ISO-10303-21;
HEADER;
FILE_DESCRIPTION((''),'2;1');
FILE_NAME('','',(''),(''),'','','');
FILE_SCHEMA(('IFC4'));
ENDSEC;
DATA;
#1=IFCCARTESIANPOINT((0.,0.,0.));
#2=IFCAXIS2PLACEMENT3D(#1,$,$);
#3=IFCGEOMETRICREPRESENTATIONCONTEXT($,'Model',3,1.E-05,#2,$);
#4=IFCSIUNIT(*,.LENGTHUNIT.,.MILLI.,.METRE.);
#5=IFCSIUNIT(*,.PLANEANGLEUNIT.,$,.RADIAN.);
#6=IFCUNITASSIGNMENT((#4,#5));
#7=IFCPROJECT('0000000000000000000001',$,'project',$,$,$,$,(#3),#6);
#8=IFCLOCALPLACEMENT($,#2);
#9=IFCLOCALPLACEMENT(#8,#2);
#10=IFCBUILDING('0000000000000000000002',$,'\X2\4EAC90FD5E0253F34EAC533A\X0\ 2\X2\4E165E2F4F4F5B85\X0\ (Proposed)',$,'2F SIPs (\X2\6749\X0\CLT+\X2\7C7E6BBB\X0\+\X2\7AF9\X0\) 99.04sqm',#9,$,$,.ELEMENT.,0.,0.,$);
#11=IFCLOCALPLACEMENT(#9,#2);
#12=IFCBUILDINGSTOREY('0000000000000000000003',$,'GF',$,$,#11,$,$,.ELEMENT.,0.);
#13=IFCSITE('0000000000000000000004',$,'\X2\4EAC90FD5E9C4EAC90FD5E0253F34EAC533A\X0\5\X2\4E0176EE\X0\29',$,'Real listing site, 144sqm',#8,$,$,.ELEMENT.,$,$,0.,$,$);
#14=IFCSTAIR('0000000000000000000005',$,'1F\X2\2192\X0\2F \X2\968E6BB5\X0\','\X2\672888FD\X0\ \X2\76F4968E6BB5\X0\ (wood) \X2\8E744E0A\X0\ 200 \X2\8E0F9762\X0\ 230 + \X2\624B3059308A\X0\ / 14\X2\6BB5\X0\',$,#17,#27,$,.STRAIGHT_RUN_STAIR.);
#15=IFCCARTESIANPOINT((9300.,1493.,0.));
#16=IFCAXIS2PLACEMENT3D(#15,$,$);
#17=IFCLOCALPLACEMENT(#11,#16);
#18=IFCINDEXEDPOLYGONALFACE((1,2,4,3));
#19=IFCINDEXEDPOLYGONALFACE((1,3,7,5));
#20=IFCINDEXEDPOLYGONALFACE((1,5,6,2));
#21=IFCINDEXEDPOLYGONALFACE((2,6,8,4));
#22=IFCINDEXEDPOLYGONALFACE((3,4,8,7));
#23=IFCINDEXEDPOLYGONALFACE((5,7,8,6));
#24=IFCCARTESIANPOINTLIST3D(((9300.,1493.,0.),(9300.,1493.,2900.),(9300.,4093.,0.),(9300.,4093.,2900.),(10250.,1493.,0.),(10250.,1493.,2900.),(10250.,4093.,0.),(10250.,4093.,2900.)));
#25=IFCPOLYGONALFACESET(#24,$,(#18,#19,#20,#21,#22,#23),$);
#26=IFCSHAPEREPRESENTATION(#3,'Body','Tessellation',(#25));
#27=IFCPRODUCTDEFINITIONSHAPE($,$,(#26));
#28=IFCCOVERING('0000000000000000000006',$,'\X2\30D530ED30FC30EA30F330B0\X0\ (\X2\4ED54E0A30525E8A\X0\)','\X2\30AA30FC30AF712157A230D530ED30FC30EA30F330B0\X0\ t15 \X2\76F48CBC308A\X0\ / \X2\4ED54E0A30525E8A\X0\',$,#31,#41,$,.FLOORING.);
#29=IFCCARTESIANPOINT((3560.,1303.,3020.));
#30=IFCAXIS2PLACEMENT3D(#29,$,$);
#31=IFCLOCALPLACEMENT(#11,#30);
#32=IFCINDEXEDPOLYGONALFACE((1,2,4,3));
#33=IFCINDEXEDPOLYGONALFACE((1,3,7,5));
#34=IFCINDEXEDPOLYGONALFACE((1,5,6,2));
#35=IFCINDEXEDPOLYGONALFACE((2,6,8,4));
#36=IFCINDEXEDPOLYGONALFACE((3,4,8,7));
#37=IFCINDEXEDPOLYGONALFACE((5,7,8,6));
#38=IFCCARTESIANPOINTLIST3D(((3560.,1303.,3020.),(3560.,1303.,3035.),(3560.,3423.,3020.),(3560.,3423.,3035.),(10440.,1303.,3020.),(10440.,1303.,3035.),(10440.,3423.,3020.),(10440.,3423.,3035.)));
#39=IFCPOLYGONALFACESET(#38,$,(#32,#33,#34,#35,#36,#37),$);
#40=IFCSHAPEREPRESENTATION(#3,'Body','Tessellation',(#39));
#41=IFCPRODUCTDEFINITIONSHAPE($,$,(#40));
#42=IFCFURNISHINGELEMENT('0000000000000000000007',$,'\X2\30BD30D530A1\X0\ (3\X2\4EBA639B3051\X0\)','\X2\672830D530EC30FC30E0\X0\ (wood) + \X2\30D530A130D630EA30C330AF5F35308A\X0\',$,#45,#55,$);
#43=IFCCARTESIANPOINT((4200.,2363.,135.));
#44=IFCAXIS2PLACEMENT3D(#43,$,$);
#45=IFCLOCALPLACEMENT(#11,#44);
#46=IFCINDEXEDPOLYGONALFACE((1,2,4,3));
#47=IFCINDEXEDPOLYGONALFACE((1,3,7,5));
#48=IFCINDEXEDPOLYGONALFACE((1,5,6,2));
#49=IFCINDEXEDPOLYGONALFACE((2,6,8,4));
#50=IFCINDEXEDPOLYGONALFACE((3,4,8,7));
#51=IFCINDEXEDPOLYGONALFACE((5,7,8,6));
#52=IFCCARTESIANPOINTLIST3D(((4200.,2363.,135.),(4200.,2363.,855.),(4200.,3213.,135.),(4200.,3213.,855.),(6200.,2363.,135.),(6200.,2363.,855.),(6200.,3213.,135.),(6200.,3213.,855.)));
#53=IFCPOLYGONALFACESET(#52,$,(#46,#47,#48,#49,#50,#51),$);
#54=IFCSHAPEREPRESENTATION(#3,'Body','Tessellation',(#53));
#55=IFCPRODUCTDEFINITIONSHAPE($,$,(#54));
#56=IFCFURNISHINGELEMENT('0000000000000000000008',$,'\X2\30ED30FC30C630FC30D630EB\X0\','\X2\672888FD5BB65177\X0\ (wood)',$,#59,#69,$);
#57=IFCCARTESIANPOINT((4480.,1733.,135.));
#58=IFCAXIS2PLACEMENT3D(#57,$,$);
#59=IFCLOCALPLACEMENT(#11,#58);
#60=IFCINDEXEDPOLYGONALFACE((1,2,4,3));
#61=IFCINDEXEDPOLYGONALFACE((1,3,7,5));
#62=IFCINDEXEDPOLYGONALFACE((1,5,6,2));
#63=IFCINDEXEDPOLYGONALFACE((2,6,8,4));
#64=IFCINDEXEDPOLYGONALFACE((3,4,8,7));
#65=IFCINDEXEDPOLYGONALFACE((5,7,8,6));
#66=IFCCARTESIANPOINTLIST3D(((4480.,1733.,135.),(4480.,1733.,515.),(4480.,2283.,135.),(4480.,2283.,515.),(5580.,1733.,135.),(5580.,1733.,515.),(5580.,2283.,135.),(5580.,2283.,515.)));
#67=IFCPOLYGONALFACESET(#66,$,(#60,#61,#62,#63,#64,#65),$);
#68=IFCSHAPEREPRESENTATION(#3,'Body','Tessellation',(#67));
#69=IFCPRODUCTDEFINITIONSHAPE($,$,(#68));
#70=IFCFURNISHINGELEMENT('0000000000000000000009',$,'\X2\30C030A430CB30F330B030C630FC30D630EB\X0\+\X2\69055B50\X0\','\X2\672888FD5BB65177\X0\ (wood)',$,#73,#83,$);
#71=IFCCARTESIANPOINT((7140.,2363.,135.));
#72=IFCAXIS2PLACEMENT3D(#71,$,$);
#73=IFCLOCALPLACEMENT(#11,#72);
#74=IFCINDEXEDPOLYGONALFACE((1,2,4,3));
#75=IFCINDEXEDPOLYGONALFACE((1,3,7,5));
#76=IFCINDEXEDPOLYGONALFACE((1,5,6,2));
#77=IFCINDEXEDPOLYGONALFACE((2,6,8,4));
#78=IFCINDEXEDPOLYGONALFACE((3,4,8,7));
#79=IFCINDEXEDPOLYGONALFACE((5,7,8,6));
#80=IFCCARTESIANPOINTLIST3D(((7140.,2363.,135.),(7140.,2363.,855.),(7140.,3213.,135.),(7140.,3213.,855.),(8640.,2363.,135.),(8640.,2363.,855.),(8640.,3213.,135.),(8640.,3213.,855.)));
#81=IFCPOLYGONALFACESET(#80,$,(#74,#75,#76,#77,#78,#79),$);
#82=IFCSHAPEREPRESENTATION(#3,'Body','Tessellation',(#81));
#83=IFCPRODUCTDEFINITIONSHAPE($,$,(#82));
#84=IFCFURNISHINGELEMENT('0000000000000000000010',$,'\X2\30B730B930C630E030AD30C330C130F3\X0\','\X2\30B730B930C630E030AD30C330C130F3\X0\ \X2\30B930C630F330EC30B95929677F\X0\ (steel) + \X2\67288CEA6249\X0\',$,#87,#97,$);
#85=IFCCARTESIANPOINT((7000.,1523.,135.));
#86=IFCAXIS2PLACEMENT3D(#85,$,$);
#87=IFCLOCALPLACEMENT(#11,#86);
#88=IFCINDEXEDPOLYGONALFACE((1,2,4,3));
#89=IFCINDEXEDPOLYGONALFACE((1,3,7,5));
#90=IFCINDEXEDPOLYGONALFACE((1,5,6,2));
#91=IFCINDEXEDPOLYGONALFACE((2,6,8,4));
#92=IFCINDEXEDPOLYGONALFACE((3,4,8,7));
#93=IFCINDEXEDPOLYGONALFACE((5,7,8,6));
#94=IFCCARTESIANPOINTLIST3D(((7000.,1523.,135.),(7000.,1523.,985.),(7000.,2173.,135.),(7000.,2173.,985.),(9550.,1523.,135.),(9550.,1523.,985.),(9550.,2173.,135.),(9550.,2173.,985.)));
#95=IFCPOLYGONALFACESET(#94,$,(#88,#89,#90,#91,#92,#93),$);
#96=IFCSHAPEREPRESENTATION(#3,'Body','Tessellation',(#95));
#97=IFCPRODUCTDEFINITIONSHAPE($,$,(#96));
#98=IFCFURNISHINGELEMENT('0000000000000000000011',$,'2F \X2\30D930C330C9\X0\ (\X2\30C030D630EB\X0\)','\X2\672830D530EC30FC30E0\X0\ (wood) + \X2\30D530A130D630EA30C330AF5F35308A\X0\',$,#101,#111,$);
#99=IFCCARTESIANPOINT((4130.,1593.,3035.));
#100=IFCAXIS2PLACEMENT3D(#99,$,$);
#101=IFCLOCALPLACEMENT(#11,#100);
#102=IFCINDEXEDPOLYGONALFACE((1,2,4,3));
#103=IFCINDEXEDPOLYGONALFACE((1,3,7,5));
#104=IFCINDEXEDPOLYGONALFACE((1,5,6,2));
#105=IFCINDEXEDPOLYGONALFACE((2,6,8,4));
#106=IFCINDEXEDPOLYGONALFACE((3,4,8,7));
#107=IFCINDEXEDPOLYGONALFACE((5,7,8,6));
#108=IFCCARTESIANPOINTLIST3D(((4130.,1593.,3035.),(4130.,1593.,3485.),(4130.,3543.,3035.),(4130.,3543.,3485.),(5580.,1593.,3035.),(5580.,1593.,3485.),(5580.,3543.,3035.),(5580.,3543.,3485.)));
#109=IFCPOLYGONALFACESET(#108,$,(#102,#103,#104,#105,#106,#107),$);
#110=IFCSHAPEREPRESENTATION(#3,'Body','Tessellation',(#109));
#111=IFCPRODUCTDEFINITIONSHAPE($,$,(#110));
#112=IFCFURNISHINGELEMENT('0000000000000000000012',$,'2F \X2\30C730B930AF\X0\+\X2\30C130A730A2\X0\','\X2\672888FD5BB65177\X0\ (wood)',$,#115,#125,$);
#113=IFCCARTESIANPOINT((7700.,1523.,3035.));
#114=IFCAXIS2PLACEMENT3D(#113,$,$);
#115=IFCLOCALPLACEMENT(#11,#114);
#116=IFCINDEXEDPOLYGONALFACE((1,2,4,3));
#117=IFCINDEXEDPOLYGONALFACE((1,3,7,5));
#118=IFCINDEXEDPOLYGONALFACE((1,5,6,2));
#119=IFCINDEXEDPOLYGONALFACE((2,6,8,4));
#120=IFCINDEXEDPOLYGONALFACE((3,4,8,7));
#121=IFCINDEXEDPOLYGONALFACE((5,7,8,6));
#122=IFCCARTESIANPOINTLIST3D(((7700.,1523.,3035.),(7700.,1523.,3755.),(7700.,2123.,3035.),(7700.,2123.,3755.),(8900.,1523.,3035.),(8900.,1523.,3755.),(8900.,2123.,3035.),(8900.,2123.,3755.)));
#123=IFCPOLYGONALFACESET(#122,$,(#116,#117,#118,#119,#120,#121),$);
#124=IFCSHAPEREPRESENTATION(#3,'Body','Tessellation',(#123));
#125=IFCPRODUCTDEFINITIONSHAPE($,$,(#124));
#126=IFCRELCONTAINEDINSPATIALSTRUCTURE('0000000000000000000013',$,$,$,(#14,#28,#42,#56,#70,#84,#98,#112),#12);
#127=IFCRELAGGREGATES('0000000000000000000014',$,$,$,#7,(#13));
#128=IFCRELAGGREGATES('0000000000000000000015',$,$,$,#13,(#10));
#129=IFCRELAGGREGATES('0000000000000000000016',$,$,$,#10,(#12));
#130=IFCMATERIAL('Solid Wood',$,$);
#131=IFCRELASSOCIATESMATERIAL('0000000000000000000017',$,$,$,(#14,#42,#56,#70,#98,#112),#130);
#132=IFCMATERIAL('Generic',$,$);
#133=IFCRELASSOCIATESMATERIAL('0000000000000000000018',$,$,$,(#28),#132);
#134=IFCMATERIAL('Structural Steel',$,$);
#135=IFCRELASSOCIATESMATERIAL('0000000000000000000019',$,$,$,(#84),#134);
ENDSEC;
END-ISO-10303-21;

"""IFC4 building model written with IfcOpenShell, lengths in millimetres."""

from ifc_helpers import new_model, si_unit, frame, frame_2d, origin, place, context, project, spatial, rectangle, extrude, material, element, save


model = new_model("IFC4")

# Units and contexts
model_context = context("Model", 3, precision=1e-05, world=origin())
ifc_project = project(units=[si_unit("LENGTHUNIT", "METRE", prefix="MILLI"), si_unit("PLANEANGLEUNIT", "RADIAN")], contexts=[model_context])

# Site, building, storey
site_placement = place(None, origin())
site = spatial("IfcSite", under=ifc_project, at=site_placement, Name="京都府京都市右京区5丁目29", ObjectType="Real listing site, 144sqm", CompositionType="ELEMENT", RefElevation=0.0)
building_placement = place(site_placement, origin())
building = spatial("IfcBuilding", under=site, at=building_placement, Name="京都市右京区 2世帯住宅 (Proposed)", ObjectType="2F SIPs (杉CLT+籾殻+竹) 99.04sqm", CompositionType="ELEMENT", ElevationOfRefHeight=0.0, ElevationOfTerrain=0.0)
storey_placement = place(building_placement, origin())
storey = spatial("IfcBuildingStorey", under=building, at=storey_placement, Name="GF", CompositionType="ELEMENT", Elevation=0.0)

# Shared definitions
ifc_material_1 = material(Name="Solid Wood")

# Shared definitions
ifc_material_2 = material(Name="Generic")

# Stair
stair_placement = place(storey_placement, frame((9300.0, 1493.0, 0.0)))
element("IfcStair", 1, at=stair_placement, inside=storey, material=ifc_material_1, Name="1F→2F 階段", Description="木製 直階段 (wood) 蹴上 200 踏面 230 + 手すり / 14段", PredefinedType="STRAIGHT_RUN_STAIR", context=model_context, shape_type="SweptSolid", body=[
    extrude(rectangle(XDim=950.0, YDim=2600.0, at=frame_2d((475.0, 1300.0))), frame((9300.0, 1493.0, 0.0)), (0.0, 0.0, 1.0), 2900.0),
])

# Covering
covering_placement = place(storey_placement, frame((3560.0, 1303.0, 3020.0)))
element("IfcCovering", 2, at=covering_placement, inside=storey, material=ifc_material_2, Name="フローリング (仕上げ床)", Description="オーク無垢フローリング t15 直貼り / 仕上げ床", PredefinedType="FLOORING", context=model_context, shape_type="SweptSolid", body=[
    extrude(rectangle(XDim=6880.0, YDim=2120.0, at=frame_2d((3440.0, 1060.0))), frame((3560.0, 1303.0, 3020.0)), (0.0, 0.0, 1.0), 15.0),
])

# Furnishing elements
furnishing_1_placement = place(storey_placement, frame((4200.0, 2363.0, 135.0)))
element("IfcFurnishingElement", 3, at=furnishing_1_placement, inside=storey, material=ifc_material_1, Name="ソファ (3人掛け)", Description="木フレーム (wood) + ファブリック張り", context=model_context, shape_type="SweptSolid", body=[
    extrude(rectangle(XDim=2000.0, YDim=850.0, at=frame_2d((1000.0, 425.0))), frame((4200.0, 2363.0, 135.0)), (0.0, 0.0, 1.0), 720.0),
])
furnishing_2_placement = place(storey_placement, frame((4480.0, 1733.0, 135.0)))
element("IfcFurnishingElement", 4, at=furnishing_2_placement, inside=storey, material=ifc_material_1, Name="ローテーブル", Description="木製家具 (wood)", context=model_context, shape_type="SweptSolid", body=[
    extrude(rectangle(XDim=1100.0, YDim=550.0, at=frame_2d((550.0, 275.0))), frame((4480.0, 1733.0, 135.0)), (0.0, 0.0, 1.0), 380.0),
])
furnishing_3_placement = place(storey_placement, frame((7140.0, 2363.0, 135.0)))
element("IfcFurnishingElement", 5, at=furnishing_3_placement, inside=storey, material=ifc_material_1, Name="ダイニングテーブル+椅子", Description="木製家具 (wood)", context=model_context, shape_type="SweptSolid", body=[
    extrude(rectangle(XDim=1500.0, YDim=850.0, at=frame_2d((750.0, 425.0))), frame((7140.0, 2363.0, 135.0)), (0.0, 0.0, 1.0), 720.0),
])
ifc_material_3 = material(Name="Structural Steel")
furnishing_4_placement = place(storey_placement, frame((7000.0, 1523.0, 135.0)))
element("IfcFurnishingElement", 6, at=furnishing_4_placement, inside=storey, material=ifc_material_3, Name="システムキッチン", Description="システムキッチン ステンレス天板 (steel) + 木質扉", context=model_context, shape_type="SweptSolid", body=[
    extrude(rectangle(XDim=2550.0, YDim=650.0, at=frame_2d((1275.0, 325.0))), frame((7000.0, 1523.0, 135.0)), (0.0, 0.0, 1.0), 850.0),
])
furnishing_5_placement = place(storey_placement, frame((4130.0, 1593.0, 3035.0)))
element("IfcFurnishingElement", 7, at=furnishing_5_placement, inside=storey, material=ifc_material_1, Name="2F ベッド (ダブル)", Description="木フレーム (wood) + ファブリック張り", context=model_context, shape_type="SweptSolid", body=[
    extrude(rectangle(XDim=1450.0, YDim=1950.0, at=frame_2d((725.0, 975.0))), frame((4130.0, 1593.0, 3035.0)), (0.0, 0.0, 1.0), 450.0),
])
furnishing_6_placement = place(storey_placement, frame((7700.0, 1523.0, 3035.0)))
element("IfcFurnishingElement", 8, at=furnishing_6_placement, inside=storey, material=ifc_material_1, Name="2F デスク+チェア", Description="木製家具 (wood)", context=model_context, shape_type="SweptSolid", body=[
    extrude(rectangle(XDim=1200.0, YDim=600.0, at=frame_2d((600.0, 300.0))), frame((7700.0, 1523.0, 3035.0)), (0.0, 0.0, 1.0), 720.0),
])

save(model, "model.ifc")
